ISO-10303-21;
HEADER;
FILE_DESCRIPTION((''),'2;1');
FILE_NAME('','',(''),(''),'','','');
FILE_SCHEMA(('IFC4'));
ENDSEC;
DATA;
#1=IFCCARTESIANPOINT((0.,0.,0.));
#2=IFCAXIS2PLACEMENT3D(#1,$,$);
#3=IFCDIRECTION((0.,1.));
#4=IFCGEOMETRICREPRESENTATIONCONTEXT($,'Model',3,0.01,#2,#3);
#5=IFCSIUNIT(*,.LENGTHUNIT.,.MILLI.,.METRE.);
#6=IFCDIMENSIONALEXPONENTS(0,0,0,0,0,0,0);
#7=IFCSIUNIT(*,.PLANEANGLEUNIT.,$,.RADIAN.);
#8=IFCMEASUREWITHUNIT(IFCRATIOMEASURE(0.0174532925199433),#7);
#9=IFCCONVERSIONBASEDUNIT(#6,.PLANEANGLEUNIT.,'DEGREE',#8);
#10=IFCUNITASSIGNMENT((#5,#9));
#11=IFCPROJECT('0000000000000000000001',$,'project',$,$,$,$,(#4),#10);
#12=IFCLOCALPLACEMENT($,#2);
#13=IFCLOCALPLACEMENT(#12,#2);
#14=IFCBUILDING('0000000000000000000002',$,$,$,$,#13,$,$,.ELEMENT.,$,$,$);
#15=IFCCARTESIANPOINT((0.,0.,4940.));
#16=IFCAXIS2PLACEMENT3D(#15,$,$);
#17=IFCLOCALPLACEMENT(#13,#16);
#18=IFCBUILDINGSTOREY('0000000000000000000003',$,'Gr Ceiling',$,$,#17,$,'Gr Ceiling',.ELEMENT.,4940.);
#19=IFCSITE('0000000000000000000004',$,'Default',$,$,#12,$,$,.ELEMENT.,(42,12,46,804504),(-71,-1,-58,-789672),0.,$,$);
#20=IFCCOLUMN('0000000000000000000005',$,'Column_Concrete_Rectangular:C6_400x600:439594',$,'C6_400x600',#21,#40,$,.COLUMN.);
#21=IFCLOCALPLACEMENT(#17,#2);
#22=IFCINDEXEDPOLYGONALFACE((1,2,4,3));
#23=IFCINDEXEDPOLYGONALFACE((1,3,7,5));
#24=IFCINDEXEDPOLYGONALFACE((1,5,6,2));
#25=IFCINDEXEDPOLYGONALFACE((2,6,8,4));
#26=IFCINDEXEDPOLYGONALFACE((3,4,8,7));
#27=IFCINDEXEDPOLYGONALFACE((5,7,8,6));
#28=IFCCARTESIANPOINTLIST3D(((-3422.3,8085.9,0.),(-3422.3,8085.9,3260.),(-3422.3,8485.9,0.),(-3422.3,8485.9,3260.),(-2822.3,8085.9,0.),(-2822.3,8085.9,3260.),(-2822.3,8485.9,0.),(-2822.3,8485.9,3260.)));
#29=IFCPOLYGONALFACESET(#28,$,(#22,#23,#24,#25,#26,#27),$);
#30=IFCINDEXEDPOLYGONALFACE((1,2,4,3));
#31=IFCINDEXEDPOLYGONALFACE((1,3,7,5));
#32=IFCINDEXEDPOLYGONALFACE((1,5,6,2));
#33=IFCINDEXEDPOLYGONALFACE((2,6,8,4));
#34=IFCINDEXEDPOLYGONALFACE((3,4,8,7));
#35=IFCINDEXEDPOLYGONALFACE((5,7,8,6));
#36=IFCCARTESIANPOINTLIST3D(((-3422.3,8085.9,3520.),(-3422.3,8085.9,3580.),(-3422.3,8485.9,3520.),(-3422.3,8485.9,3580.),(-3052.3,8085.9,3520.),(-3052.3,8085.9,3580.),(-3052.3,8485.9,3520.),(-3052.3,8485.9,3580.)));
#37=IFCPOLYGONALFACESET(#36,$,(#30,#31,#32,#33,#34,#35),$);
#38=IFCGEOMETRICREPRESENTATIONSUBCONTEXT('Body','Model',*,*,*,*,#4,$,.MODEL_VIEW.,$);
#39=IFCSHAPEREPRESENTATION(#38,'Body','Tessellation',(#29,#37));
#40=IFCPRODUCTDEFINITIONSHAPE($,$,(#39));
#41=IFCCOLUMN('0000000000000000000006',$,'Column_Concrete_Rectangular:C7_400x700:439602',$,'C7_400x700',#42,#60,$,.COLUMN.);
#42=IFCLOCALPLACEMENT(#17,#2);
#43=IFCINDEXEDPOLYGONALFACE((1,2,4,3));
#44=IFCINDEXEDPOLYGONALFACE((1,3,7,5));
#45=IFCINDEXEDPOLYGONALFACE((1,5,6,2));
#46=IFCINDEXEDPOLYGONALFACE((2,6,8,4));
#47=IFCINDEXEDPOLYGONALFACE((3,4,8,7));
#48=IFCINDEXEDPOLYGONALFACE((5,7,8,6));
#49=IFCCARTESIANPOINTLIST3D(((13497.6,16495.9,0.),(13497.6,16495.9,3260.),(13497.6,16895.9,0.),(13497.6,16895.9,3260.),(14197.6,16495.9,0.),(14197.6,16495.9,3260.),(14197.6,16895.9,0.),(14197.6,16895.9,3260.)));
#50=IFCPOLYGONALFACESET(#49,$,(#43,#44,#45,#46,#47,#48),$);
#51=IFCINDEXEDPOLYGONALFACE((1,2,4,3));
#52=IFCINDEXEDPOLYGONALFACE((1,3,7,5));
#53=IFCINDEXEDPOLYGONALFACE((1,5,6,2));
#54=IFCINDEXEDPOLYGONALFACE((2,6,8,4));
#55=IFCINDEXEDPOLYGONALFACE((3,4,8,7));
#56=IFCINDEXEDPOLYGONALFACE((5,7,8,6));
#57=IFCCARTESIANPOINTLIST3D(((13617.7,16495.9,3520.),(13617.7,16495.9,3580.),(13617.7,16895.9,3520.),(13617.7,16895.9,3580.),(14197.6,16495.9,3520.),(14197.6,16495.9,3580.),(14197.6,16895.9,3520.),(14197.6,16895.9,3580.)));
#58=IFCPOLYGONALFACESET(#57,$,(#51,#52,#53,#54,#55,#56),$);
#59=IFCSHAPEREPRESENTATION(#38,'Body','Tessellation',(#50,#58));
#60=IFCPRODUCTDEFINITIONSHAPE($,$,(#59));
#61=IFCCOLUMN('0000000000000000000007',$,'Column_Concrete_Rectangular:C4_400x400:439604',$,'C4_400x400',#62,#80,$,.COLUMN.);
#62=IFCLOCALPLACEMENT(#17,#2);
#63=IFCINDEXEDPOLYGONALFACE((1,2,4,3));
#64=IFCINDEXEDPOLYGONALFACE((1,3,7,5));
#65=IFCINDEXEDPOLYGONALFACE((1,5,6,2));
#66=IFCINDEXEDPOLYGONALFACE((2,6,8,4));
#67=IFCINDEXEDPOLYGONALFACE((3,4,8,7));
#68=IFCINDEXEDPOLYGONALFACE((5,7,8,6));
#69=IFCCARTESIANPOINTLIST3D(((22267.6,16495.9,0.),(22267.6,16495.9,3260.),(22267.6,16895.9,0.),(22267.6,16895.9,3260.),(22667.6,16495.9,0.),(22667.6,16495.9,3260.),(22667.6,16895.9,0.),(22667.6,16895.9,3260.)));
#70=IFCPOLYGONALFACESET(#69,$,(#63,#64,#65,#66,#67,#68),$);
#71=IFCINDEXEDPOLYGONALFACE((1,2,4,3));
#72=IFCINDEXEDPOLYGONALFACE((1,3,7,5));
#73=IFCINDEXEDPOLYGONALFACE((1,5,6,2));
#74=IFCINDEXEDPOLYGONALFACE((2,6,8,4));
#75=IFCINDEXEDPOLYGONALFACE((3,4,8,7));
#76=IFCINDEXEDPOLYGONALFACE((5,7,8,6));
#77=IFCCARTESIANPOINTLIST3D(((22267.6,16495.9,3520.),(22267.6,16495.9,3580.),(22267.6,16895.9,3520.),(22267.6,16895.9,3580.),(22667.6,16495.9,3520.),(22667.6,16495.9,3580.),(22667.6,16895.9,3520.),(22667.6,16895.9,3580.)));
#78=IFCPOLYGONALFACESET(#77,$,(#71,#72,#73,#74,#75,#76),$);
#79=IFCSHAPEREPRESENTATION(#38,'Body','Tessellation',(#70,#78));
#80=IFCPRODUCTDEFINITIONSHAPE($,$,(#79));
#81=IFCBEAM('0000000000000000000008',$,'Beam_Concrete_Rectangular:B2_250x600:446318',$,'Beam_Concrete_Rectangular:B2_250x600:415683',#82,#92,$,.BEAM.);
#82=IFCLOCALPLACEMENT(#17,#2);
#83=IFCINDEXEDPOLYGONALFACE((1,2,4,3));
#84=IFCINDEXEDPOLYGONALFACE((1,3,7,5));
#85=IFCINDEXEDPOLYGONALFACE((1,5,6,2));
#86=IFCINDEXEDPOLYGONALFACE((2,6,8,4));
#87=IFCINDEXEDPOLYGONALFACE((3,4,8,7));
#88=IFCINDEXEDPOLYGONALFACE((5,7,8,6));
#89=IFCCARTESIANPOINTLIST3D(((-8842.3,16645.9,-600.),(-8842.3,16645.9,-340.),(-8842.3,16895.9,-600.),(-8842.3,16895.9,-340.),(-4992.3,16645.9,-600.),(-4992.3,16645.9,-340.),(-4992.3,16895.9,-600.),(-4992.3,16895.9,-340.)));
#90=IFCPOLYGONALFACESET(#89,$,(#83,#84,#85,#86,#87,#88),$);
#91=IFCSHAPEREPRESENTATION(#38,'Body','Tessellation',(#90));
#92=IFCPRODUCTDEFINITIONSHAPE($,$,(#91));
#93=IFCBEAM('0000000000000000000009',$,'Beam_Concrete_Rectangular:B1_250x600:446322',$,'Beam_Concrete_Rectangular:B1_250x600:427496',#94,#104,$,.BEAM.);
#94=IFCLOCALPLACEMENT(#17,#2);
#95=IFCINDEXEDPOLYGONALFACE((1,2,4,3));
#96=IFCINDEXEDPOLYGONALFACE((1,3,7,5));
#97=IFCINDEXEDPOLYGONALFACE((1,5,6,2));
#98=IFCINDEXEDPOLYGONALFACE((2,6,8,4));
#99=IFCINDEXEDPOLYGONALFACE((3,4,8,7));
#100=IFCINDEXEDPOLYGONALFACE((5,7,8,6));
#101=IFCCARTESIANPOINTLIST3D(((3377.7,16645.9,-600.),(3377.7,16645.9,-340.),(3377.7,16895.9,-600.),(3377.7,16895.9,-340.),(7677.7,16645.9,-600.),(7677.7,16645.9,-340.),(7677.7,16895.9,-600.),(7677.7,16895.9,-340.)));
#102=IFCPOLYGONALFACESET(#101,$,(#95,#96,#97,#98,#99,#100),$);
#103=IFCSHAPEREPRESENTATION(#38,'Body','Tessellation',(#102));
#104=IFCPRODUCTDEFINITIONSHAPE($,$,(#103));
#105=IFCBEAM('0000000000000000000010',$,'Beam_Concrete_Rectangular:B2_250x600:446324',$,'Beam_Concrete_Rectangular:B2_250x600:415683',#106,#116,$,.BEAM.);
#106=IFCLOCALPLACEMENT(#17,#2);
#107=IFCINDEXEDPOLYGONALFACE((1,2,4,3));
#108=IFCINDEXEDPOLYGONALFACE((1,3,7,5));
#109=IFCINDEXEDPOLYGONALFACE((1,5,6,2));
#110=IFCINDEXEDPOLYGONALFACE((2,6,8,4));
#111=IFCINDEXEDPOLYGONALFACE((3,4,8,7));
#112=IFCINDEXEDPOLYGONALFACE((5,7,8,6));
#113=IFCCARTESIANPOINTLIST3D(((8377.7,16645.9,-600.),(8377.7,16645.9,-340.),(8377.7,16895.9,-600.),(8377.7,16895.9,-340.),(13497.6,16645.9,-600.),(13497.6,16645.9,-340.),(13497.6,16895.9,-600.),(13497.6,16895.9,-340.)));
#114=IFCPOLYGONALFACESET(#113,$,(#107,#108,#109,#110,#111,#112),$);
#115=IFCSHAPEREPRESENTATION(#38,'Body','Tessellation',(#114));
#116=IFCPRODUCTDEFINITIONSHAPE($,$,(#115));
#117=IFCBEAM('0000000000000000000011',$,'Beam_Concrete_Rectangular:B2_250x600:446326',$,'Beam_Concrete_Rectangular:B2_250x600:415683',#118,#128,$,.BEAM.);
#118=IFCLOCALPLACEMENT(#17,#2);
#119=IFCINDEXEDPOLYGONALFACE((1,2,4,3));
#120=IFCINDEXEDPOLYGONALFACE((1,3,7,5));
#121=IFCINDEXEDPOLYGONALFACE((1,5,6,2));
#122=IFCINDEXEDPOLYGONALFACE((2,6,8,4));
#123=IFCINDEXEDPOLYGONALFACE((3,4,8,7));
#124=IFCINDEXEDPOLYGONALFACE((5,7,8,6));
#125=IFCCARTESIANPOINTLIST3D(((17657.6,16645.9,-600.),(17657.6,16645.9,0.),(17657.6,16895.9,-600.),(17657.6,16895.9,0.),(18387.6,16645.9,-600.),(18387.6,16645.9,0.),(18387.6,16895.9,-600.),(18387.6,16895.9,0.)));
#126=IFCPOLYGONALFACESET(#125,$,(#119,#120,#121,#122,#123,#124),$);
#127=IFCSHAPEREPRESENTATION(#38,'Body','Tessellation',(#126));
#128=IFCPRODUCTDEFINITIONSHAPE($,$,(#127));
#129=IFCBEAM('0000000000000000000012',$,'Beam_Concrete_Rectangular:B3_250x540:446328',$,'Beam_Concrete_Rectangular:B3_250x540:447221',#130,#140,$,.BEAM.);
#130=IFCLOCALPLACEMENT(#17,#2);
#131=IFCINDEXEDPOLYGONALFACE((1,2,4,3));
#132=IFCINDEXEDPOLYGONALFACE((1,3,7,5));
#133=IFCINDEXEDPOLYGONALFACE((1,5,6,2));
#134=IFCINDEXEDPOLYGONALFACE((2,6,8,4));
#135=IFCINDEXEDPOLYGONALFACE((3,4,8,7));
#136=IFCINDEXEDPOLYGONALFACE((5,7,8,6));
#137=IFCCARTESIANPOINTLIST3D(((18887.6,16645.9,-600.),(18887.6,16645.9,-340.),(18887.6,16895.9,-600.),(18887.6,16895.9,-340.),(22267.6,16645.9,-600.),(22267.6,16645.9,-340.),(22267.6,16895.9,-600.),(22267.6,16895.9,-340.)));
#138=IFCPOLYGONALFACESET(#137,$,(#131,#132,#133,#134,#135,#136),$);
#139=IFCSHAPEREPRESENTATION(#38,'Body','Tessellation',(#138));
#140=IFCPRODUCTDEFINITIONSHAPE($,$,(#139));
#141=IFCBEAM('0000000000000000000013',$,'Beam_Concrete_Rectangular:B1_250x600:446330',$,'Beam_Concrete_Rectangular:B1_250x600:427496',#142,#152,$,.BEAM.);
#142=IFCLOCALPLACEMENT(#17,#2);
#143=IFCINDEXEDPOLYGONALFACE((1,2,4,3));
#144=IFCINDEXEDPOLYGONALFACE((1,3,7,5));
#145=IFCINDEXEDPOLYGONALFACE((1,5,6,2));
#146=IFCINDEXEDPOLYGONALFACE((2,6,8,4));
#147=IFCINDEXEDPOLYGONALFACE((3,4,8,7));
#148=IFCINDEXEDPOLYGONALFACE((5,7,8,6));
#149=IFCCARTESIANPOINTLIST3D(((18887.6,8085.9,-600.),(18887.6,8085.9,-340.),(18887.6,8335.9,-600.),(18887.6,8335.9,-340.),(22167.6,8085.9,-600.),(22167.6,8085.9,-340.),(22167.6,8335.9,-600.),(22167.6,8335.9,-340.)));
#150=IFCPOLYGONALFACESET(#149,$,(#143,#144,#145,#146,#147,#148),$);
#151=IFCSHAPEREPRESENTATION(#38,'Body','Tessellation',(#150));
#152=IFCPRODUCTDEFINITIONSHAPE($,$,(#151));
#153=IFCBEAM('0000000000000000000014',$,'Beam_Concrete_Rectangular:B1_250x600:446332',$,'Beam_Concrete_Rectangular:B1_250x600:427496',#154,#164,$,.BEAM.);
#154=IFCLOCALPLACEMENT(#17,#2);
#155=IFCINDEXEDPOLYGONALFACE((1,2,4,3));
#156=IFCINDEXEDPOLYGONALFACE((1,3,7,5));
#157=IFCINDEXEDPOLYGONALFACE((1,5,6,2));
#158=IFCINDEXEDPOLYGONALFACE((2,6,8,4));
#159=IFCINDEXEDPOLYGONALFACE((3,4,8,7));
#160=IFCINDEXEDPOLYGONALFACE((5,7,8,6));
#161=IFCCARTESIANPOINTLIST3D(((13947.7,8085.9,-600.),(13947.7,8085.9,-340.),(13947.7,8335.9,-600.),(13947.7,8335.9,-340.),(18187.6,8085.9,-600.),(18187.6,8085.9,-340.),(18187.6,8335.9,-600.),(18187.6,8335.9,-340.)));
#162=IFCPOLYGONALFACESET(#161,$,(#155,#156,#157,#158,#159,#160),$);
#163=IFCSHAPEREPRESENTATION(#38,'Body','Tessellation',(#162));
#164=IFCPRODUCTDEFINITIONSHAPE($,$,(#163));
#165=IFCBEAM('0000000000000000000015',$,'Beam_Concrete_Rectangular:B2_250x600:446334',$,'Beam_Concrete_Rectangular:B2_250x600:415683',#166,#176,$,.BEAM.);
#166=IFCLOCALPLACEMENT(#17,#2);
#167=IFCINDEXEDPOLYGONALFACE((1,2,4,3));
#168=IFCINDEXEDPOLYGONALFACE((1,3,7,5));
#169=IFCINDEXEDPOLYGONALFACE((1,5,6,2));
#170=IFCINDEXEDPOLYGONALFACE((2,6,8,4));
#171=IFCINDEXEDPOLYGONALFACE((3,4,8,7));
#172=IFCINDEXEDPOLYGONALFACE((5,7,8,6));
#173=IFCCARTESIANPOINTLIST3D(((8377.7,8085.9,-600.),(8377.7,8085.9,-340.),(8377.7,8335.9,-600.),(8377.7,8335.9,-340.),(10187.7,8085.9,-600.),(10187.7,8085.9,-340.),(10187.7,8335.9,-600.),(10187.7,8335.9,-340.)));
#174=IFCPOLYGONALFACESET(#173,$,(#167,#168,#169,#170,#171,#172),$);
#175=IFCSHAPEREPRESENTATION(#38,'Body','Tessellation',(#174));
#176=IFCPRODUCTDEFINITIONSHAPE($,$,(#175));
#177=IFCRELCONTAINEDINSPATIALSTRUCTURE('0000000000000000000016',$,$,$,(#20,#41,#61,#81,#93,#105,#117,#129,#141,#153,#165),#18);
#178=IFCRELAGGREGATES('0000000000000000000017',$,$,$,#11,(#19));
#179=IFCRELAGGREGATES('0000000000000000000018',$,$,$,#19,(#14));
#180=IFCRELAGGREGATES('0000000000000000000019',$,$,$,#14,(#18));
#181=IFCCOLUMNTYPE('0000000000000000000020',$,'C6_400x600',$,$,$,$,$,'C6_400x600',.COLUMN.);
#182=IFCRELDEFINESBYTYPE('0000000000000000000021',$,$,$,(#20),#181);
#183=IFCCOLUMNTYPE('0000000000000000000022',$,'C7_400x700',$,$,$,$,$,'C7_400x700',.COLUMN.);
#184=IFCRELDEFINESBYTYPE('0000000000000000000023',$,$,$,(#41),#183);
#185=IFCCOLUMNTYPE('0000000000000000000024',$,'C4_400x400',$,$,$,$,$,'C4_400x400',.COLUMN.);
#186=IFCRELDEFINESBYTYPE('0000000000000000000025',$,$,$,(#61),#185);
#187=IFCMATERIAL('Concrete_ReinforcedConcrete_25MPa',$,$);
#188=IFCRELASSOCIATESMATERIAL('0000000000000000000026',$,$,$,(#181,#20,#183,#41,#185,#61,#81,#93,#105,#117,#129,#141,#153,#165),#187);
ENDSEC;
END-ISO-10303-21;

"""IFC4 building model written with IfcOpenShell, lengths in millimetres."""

from ifc_helpers import new_model, entity, si_unit, converted_unit, direction, frame, frame_2d, origin, origin_2d_with_axis, place, context, subcontext, project, spatial, rectangle, extrude, source, transform, mapped, material, type_object, type_shapes, element, save


model = new_model("IFC4")

# Units and contexts
model_context = context("Model", 3, precision=0.01, world=origin(), true_north=direction((0.0, 1.0)))
body_context = subcontext(model_context, "Body", "Model", "MODEL_VIEW")
ifc_project = project(units=[si_unit("LENGTHUNIT", "METRE", prefix="MILLI"), converted_unit("PLANEANGLEUNIT", "DEGREE", entity("IfcRatioMeasure", 0.0174532925199433), si_unit("PLANEANGLEUNIT", "RADIAN"), dimensions=[0, 0, 0, 0, 0, 0, 0])], contexts=[model_context])

# Site, building, storey
site_placement = place(None, origin())
site = spatial("IfcSite", under=ifc_project, at=site_placement, Name="Default", CompositionType="ELEMENT", RefLatitude=(42, 12, 46, 804504), RefLongitude=(-71, -1, -58, -789672), RefElevation=0.0)
building_placement = place(site_placement, origin())
building = spatial("IfcBuilding", under=site, at=building_placement, CompositionType="ELEMENT")
storey_placement = place(building_placement, frame((0.0, 0.0, 4940.0)))
storey = spatial("IfcBuildingStorey", under=building, at=storey_placement, Name="Gr Ceiling", LongName="Gr Ceiling", CompositionType="ELEMENT", Elevation=4940.0)

# Columns
ifc_material = material(Name="Concrete_ReinforcedConcrete_25MPa")
column_type_1 = type_object("IfcColumnType", Name="C6_400x600", ElementType="C6_400x600", PredefinedType="COLUMN", material=ifc_material)
shared_shape_1 = source(origin(), body_context, "Body", "SweptSolid", [
    extrude(rectangle(XDim=400.0, YDim=600.0, at=origin_2d_with_axis()), frame((-3122.3, 8285.9, 4940.0), z_axis=(0.0, 0.0, 1.0), x_axis=(0.0, -1.0, 0.0)), (0.0, 0.0, 1.0), 3260.0),
    extrude(rectangle(XDim=400.0, YDim=370.0, at=frame_2d((0.0, 0.0), x_axis=(1.0, 0.0))), frame((-3237.3, 8285.9, 8460.0), z_axis=(0.0, 0.0, 1.0), x_axis=(0.0, -1.0, 0.0)), (0.0, 0.0, 1.0), 60.0),
])
type_shapes(column_type_1, [shared_shape_1])
column_1_placement = place(storey_placement, frame((0.0, 0.0, -4940.0)))
element("IfcColumn", 1, at=column_1_placement, inside=storey, type_object=column_type_1, material=ifc_material, Name="Column_Concrete_Rectangular:C6_400x600:439594", ObjectType="C6_400x600", PredefinedType="COLUMN", context=body_context, shape_type="MappedRepresentation", body=[
    mapped(shared_shape_1, transform((0.0, 0.0, 0.0), scale=1.0)),
])
column_type_2 = type_object("IfcColumnType", Name="C7_400x700", ElementType="C7_400x700", PredefinedType="COLUMN", material=ifc_material)
shared_shape_2 = source(origin(), body_context, "Body", "SweptSolid", [
    extrude(rectangle(XDim=400.0, YDim=700.0, at=frame_2d((0.0, 0.0), x_axis=(1.0, 0.0))), frame((13847.6, 16695.9, 4940.0), z_axis=(0.0, 0.0, 1.0), x_axis=(0.0, -1.0, 0.0)), (0.0, 0.0, 1.0), 3260.0),
    extrude(rectangle(XDim=400.0, YDim=580.0, at=frame_2d((0.0, 0.0), x_axis=(1.0, 0.0))), frame((13907.6, 16695.9, 8460.0), z_axis=(0.0, 0.0, 1.0), x_axis=(0.0, -1.0, 0.0)), (0.0, 0.0, 1.0), 60.0),
])
type_shapes(column_type_2, [shared_shape_2])
column_2_placement = place(storey_placement, frame((0.0, 0.0, -4940.0)))
element("IfcColumn", 2, at=column_2_placement, inside=storey, type_object=column_type_2, material=ifc_material, Name="Column_Concrete_Rectangular:C7_400x700:439602", ObjectType="C7_400x700", PredefinedType="COLUMN", context=body_context, shape_type="MappedRepresentation", body=[
    mapped(shared_shape_2, transform((0.0, 0.0, 0.0), scale=1.0)),
])
column_type_3 = type_object("IfcColumnType", Name="C4_400x400", ElementType="C4_400x400", PredefinedType="COLUMN", material=ifc_material)
shared_shape_3 = source(origin(), body_context, "Body", "SweptSolid", [
    extrude(rectangle(XDim=400.0, YDim=400.0, at=frame_2d((0.0, 0.0), x_axis=(1.0, 0.0))), frame((22467.6, 16695.9, 4940.0), z_axis=(0.0, 0.0, 1.0), x_axis=(0.0, -1.0, 0.0)), (0.0, 0.0, 1.0), 3260.0),
    extrude(rectangle(XDim=400.0, YDim=400.0, at=frame_2d((0.0, 0.0), x_axis=(1.0, 0.0))), frame((22467.6, 16695.9, 8460.0), z_axis=(0.0, 0.0, 1.0), x_axis=(0.0, -1.0, 0.0)), (0.0, 0.0, 1.0), 60.0),
])
type_shapes(column_type_3, [shared_shape_3])
column_3_placement = place(storey_placement, frame((0.0, 0.0, -4940.0)))
element("IfcColumn", 3, at=column_3_placement, inside=storey, type_object=column_type_3, material=ifc_material, Name="Column_Concrete_Rectangular:C4_400x400:439604", ObjectType="C4_400x400", PredefinedType="COLUMN", context=body_context, shape_type="MappedRepresentation", body=[
    mapped(shared_shape_3, transform((0.0, 0.0, 0.0), scale=1.0)),
])

# Beams
beam_1_placement = place(storey_placement, frame((-9042.3, 16645.9, 0.0)))
element("IfcBeam", 4, at=beam_1_placement, inside=storey, material=ifc_material, Name="Beam_Concrete_Rectangular:B2_250x600:446318", ObjectType="Beam_Concrete_Rectangular:B2_250x600:415683", PredefinedType="BEAM", context=body_context, shape_type="SweptSolid", body=[
    extrude(rectangle(XDim=260.0, YDim=250.0, at=origin_2d_with_axis()), frame((200.0, 125.0, -470.0), z_axis=(1.0, 0.0, 0.0), x_axis=(0.0, 0.0, -1.0)), (0.0, 0.0, 1.0), 3850.0),
])
beam_2_placement = place(storey_placement, frame((8027.7, 16895.9, 0.0), z_axis=(0.0, 0.0, 1.0), x_axis=(-1.0, 0.0, 0.0)))
element("IfcBeam", 5, at=beam_2_placement, inside=storey, material=ifc_material, Name="Beam_Concrete_Rectangular:B1_250x600:446322", ObjectType="Beam_Concrete_Rectangular:B1_250x600:427496", PredefinedType="BEAM", context=body_context, shape_type="SweptSolid", body=[
    extrude(rectangle(XDim=260.0, YDim=250.0, at=origin_2d_with_axis()), frame((350.0, 125.0, -470.0), z_axis=(1.0, 0.0, 0.0), x_axis=(0.0, 0.0, -1.0)), (0.0, 0.0, 1.0), 4300.0),
])
beam_3_placement = place(storey_placement, frame((13847.6, 16895.9, 0.0), z_axis=(0.0, 0.0, 1.0), x_axis=(-1.0, 0.0, 0.0)))
element("IfcBeam", 6, at=beam_3_placement, inside=storey, material=ifc_material, Name="Beam_Concrete_Rectangular:B2_250x600:446324", ObjectType="Beam_Concrete_Rectangular:B2_250x600:415683", PredefinedType="BEAM", context=body_context, shape_type="SweptSolid", body=[
    extrude(rectangle(XDim=260.0, YDim=250.0, at=origin_2d_with_axis()), frame((350.0, 125.0, -470.0), z_axis=(1.0, 0.0, 0.0), x_axis=(0.0, 0.0, -1.0)), (0.0, 0.0, 1.0), 5120.0),
])
beam_4_placement = place(storey_placement, frame((18637.6, 16895.9, 0.0), z_axis=(0.0, 0.0, 1.0), x_axis=(-1.0, 0.0, 0.0)))
element("IfcBeam", 7, at=beam_4_placement, inside=storey, material=ifc_material, Name="Beam_Concrete_Rectangular:B2_250x600:446326", ObjectType="Beam_Concrete_Rectangular:B2_250x600:415683", PredefinedType="BEAM", context=body_context, shape_type="SweptSolid", body=[
    extrude(rectangle(XDim=600.0, YDim=250.0, at=frame_2d((0.0, 0.0), x_axis=(1.0, 0.0))), frame((250.0, 125.0, -300.0), z_axis=(1.0, 0.0, 0.0), x_axis=(0.0, 0.0, -1.0)), (0.0, 0.0, 1.0), 730.0),
])
beam_5_placement = place(storey_placement, frame((22467.6, 16895.9, 0.0), z_axis=(0.0, 0.0, 1.0), x_axis=(-1.0, 0.0, 0.0)))
element("IfcBeam", 8, at=beam_5_placement, inside=storey, material=ifc_material, Name="Beam_Concrete_Rectangular:B3_250x540:446328", ObjectType="Beam_Concrete_Rectangular:B3_250x540:447221", PredefinedType="BEAM", context=body_context, shape_type="SweptSolid", body=[
    extrude(rectangle(XDim=260.0, YDim=250.0, at=frame_2d((0.0, 0.0), x_axis=(1.0, 0.0))), frame((200.0, 125.0, -470.0), z_axis=(1.0, 0.0, 0.0), x_axis=(0.0, 0.0, -1.0)), (0.0, 0.0, 1.0), 3380.0),
])
beam_6_placement = place(storey_placement, frame((18537.6, 8085.9, 0.0)))
element("IfcBeam", 9, at=beam_6_placement, inside=storey, material=ifc_material, Name="Beam_Concrete_Rectangular:B1_250x600:446330", ObjectType="Beam_Concrete_Rectangular:B1_250x600:427496", PredefinedType="BEAM", context=body_context, shape_type="SweptSolid", body=[
    extrude(rectangle(XDim=260.0, YDim=250.0, at=frame_2d((0.0, 0.0), x_axis=(1.0, 0.0))), frame((350.0, 125.0, -470.0), z_axis=(1.0, 0.0, 0.0), x_axis=(0.0, 0.0, -1.0)), (0.0, 0.0, 1.0), 3280.0),
])
beam_7_placement = place(storey_placement, frame((13597.7, 8085.9, 0.0)))
element("IfcBeam", 10, at=beam_7_placement, inside=storey, material=ifc_material, Name="Beam_Concrete_Rectangular:B1_250x600:446332", ObjectType="Beam_Concrete_Rectangular:B1_250x600:427496", PredefinedType="BEAM", context=body_context, shape_type="SweptSolid", body=[
    extrude(rectangle(XDim=260.0, YDim=250.0, at=frame_2d((0.0, 0.0), x_axis=(1.0, 0.0))), frame((350.0, 125.0, -470.0), z_axis=(1.0, 0.0, 0.0), x_axis=(0.0, 0.0, -1.0)), (0.0, 0.0, 1.0), 4240.0),
])
beam_8_placement = place(storey_placement, frame((8027.7, 8085.9, 0.0)))
element("IfcBeam", 11, at=beam_8_placement, inside=storey, material=ifc_material, Name="Beam_Concrete_Rectangular:B2_250x600:446334", ObjectType="Beam_Concrete_Rectangular:B2_250x600:415683", PredefinedType="BEAM", context=body_context, shape_type="SweptSolid", body=[
    extrude(rectangle(XDim=260.0, YDim=250.0, at=frame_2d((0.0, 0.0), x_axis=(1.0, 0.0))), frame((350.0, 125.0, -470.0), z_axis=(1.0, 0.0, 0.0), x_axis=(0.0, 0.0, -1.0)), (0.0, 0.0, 1.0), 1810.0),
])

save(model, "model.ifc")
